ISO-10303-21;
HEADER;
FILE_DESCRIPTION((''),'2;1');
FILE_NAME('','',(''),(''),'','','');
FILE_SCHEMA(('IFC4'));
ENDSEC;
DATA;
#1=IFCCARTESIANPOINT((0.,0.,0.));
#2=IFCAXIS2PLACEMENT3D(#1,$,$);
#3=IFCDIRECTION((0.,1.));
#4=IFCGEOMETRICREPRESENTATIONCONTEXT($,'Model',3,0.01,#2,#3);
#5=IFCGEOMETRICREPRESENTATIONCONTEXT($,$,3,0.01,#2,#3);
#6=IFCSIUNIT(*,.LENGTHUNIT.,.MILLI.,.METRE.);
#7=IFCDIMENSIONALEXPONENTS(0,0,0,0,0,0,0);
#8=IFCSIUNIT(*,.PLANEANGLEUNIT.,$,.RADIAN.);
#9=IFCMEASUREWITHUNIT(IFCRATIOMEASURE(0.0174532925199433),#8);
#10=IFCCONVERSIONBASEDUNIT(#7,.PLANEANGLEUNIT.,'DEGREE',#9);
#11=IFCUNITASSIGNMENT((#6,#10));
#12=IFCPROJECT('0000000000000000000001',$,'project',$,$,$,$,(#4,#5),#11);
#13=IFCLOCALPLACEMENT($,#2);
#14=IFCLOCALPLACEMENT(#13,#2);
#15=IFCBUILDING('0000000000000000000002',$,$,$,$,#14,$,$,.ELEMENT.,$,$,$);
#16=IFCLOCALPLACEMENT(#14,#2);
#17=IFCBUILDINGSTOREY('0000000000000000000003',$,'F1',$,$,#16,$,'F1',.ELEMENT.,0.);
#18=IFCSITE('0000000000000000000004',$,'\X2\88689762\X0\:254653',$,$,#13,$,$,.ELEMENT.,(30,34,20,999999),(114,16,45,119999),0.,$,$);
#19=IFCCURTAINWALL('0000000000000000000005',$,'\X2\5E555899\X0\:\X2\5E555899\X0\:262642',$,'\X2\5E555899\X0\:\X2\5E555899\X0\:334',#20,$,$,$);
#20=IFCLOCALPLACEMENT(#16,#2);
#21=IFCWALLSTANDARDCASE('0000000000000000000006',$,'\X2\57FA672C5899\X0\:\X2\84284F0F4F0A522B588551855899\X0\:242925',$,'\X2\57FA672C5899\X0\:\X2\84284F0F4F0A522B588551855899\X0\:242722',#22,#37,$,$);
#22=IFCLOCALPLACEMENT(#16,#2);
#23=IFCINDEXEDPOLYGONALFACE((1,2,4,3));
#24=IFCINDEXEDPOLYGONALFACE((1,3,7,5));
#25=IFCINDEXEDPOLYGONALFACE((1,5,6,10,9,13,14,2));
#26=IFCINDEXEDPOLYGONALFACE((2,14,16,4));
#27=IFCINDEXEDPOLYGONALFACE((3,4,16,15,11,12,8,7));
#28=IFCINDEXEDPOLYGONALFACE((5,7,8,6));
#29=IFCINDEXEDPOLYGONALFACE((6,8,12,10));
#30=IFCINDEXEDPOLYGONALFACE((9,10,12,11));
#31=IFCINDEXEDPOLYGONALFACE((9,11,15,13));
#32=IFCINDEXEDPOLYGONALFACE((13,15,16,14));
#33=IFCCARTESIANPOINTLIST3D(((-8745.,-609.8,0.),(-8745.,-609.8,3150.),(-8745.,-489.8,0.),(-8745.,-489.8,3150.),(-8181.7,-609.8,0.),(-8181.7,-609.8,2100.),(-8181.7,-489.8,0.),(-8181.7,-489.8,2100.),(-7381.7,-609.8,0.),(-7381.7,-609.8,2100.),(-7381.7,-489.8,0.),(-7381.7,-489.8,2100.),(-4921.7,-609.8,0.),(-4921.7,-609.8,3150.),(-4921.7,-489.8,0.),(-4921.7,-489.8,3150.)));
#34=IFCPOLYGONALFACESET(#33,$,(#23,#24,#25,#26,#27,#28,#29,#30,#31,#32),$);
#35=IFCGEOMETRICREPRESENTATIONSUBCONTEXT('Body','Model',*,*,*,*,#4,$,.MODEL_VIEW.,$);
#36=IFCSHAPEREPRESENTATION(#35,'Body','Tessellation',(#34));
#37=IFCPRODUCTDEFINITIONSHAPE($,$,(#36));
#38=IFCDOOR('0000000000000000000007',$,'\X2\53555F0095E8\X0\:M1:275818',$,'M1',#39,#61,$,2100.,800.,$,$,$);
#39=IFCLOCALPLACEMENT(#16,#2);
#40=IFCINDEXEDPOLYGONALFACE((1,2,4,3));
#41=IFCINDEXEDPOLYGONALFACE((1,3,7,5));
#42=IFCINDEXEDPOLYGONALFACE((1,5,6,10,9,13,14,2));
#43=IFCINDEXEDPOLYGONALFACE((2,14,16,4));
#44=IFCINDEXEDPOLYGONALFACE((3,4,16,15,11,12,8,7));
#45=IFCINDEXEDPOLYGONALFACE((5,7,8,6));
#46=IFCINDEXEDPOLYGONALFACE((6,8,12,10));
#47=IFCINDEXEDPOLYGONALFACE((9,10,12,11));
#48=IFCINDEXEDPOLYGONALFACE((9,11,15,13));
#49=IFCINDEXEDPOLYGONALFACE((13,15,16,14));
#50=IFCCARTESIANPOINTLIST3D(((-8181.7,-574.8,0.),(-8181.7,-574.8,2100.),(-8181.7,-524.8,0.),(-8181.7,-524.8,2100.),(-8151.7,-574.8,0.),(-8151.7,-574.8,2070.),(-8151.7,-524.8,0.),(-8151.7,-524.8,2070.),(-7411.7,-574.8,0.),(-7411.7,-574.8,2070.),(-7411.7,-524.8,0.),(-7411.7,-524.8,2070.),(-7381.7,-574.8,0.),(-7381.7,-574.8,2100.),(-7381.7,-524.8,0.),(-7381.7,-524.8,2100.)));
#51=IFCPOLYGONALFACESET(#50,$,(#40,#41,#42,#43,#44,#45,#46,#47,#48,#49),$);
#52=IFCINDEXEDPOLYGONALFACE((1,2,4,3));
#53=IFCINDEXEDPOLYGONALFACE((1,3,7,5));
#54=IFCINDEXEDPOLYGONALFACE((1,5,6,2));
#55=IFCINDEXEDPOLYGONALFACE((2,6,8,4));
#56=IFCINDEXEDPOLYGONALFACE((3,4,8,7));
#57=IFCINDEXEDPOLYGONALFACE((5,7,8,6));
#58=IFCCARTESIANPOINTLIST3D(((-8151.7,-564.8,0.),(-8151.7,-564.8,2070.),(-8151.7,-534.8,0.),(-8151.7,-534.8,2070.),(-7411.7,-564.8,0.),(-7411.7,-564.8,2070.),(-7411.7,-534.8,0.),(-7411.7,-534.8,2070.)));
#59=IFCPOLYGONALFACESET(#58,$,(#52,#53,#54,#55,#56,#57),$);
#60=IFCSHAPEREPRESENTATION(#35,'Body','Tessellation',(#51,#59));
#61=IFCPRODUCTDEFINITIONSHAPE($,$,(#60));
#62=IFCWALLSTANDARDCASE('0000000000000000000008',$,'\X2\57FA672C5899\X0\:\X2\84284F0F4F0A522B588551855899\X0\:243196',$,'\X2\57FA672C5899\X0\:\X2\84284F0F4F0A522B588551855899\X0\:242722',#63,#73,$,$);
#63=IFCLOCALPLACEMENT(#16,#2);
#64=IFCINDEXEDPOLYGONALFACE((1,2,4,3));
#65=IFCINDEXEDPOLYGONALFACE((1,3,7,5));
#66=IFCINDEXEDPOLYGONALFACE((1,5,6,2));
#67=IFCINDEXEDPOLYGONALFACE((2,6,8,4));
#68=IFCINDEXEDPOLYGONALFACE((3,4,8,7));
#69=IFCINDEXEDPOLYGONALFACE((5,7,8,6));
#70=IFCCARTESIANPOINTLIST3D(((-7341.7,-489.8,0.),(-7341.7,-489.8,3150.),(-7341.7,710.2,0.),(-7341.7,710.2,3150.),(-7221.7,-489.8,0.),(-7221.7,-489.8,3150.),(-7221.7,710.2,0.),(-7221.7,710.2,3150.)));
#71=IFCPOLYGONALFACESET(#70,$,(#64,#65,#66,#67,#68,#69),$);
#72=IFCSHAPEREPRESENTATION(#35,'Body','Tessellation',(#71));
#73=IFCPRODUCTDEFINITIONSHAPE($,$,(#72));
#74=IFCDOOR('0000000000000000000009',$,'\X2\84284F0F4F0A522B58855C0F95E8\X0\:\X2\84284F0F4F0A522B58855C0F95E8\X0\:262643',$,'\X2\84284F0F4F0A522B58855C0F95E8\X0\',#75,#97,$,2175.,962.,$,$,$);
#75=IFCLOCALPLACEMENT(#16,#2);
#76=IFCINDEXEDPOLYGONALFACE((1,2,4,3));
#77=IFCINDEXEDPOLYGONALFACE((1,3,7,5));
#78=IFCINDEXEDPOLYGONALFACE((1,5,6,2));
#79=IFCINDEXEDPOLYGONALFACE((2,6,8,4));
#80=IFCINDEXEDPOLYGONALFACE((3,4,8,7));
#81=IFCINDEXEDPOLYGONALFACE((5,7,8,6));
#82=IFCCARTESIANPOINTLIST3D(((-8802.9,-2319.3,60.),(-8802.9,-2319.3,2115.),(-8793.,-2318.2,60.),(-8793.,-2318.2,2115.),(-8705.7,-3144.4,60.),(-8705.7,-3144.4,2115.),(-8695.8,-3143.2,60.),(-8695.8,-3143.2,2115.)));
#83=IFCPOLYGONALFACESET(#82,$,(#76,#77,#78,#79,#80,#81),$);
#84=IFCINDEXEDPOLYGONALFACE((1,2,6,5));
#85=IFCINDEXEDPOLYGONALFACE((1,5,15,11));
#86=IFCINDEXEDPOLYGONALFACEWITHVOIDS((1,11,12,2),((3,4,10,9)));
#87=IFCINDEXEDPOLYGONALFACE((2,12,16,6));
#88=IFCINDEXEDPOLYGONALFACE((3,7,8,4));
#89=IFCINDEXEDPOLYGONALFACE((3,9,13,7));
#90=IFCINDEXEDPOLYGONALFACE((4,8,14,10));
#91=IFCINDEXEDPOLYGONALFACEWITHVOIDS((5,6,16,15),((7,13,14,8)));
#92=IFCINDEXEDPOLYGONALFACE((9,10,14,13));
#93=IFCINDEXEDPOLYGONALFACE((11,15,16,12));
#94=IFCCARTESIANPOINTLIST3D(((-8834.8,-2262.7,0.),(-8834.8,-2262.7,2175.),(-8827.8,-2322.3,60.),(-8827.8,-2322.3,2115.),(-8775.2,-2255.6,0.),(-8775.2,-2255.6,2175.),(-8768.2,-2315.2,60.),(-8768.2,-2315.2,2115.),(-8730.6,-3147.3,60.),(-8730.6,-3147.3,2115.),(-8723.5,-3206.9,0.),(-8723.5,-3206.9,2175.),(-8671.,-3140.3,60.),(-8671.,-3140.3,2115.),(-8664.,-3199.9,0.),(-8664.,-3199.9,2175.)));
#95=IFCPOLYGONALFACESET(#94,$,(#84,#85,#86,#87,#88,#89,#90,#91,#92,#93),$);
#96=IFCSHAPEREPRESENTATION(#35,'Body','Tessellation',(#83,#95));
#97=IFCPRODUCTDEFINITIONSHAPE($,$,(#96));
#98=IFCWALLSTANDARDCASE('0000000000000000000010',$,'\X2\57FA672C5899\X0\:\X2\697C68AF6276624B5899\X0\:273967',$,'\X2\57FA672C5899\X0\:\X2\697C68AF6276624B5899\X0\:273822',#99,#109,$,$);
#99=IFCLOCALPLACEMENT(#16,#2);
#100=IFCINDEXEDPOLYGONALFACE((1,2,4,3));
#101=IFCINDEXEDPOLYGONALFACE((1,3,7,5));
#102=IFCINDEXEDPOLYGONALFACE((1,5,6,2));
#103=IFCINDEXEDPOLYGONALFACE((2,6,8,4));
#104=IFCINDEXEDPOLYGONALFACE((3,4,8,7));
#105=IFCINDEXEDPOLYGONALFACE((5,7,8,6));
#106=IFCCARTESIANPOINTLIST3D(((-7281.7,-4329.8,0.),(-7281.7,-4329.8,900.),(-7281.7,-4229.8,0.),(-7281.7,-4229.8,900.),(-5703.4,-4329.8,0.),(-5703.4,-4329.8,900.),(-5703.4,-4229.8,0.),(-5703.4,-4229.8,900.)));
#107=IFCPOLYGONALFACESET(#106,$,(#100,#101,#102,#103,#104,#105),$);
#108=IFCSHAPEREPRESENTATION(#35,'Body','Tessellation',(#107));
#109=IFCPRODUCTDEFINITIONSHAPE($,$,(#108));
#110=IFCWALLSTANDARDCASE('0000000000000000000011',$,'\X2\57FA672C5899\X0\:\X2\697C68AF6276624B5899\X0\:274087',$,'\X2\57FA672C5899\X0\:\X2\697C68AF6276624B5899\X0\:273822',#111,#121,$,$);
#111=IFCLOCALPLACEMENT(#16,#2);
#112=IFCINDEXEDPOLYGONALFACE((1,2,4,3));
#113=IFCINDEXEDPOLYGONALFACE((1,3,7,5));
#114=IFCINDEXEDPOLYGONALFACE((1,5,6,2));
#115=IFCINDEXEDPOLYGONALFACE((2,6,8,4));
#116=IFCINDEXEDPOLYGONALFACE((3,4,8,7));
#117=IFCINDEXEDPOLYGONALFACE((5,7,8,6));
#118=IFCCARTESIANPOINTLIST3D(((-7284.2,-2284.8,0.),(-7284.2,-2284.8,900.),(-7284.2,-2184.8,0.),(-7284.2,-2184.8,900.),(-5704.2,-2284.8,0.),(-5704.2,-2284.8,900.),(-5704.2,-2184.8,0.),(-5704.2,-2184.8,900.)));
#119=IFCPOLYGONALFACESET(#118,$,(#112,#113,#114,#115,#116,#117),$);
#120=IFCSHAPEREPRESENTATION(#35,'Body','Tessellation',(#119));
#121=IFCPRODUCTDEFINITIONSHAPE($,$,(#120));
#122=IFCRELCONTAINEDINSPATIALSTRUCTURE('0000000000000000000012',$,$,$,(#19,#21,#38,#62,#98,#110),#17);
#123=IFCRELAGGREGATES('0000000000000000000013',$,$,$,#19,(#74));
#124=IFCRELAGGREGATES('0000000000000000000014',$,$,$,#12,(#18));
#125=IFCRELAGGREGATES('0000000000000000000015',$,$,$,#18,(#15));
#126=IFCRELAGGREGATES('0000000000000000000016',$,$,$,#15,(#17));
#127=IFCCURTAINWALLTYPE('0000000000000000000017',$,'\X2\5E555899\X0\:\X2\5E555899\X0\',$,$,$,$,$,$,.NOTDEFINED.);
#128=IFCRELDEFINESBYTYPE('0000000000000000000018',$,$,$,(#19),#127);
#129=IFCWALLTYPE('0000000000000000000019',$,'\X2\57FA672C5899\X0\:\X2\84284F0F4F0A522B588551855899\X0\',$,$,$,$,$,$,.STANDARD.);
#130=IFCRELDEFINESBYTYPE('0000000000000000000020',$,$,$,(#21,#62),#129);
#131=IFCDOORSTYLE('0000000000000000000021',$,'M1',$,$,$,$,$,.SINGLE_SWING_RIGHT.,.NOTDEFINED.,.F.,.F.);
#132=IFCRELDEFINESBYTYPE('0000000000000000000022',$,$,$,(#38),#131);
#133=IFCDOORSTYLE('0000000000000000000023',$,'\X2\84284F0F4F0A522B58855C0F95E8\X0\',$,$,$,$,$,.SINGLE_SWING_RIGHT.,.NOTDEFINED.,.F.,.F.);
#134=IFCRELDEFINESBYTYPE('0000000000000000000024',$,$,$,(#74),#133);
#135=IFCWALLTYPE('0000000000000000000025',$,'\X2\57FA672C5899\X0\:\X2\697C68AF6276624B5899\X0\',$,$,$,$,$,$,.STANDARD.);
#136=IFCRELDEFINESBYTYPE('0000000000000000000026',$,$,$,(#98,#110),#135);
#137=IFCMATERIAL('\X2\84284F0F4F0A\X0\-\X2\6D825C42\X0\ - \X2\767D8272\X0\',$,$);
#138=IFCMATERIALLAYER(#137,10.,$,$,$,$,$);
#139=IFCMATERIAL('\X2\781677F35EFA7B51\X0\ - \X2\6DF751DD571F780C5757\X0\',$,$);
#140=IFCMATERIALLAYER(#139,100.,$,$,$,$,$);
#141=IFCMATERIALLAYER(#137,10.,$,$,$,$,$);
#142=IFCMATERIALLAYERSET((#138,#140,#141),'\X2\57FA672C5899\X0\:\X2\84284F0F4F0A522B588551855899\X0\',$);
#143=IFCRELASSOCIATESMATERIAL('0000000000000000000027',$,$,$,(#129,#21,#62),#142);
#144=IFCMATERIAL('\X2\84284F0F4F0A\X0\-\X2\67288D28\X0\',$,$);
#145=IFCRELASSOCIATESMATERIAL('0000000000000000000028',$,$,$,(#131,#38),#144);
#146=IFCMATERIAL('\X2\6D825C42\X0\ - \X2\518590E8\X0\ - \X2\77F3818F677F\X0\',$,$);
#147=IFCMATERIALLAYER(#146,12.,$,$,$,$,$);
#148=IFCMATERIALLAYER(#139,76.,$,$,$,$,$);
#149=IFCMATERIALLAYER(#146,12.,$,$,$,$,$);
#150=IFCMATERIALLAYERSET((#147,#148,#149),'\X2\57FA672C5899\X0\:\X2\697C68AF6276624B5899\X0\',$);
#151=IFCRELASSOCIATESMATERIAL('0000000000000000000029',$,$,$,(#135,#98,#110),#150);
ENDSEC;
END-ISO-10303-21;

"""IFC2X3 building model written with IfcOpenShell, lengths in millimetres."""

from ifc_helpers import new_model, entity, si_unit, converted_unit, direction, frame, frame_2d, origin, origin_2d_with_axis, place, context, subcontext, project, spatial, polyline, rectangle, outline, extrude, clip, bounded_halfspace, source, transform, mapped, material, layer, layer_set, layer_usage, type_object, type_shapes, element, fill, aggregate, save


model = new_model("IFC2X3")

# Units and contexts
model_context = context("Model", 3, precision=0.01, world=origin(), true_north=direction((0.0, 1.0)))
context_of_model = context(None, 3, precision=0.01, world=origin(), true_north=direction((0.0, 1.0)))
body_context = subcontext(model_context, "Body", "Model", "MODEL_VIEW")
ifc_project = project(units=[si_unit("LENGTHUNIT", "METRE", prefix="MILLI"), converted_unit("PLANEANGLEUNIT", "DEGREE", entity("IfcRatioMeasure", 0.0174532925199433), si_unit("PLANEANGLEUNIT", "RADIAN"), dimensions=[0, 0, 0, 0, 0, 0, 0])], contexts=[model_context, context_of_model])

# Site, building, storey
site_placement = place(None, origin())
site = spatial("IfcSite", under=ifc_project, at=site_placement, Name="表面:254653", CompositionType="ELEMENT", RefLatitude=(30, 34, 20, 999999), RefLongitude=(114, 16, 45, 119999), RefElevation=0.0)
building_placement = place(site_placement, origin())
building = spatial("IfcBuilding", under=site, at=building_placement, CompositionType="ELEMENT")
storey_placement = place(building_placement, origin())
storey = spatial("IfcBuildingStorey", under=building, at=storey_placement, Name="F1", LongName="F1", CompositionType="ELEMENT", Elevation=0.0)

# Curtain wall
curtain_wall_type_1 = type_object("IfcCurtainWallType", Name="幕墙:幕墙", PredefinedType="NOTDEFINED")
curtain_wall_1_placement = place(storey_placement, origin())
curtain_wall_1 = element("IfcCurtainWall", 1, at=curtain_wall_1_placement, inside=storey, type_object=curtain_wall_type_1, Name="幕墙:幕墙:262642", ObjectType="幕墙:幕墙:334")

# Wall, opening, door
ifc_material_1 = material(Name="萨伏伊-涂层 - 白色")
ifc_layer_1 = layer(ifc_material_1, 10.0)
ifc_material_2 = material(Name="砖石建筑 - 混凝土砌块")
ifc_layer_2 = layer(ifc_material_2, 100.0)
ifc_layer_3 = layer(ifc_material_1, 10.0)
ifc_layer_set_1 = layer_set([ifc_layer_1, ifc_layer_2, ifc_layer_3], Name="基本墙:萨伏伊别墅内墙")
ifc_layer_usage_1 = layer_usage(ifc_layer_set_1, "AXIS2", "NEGATIVE", 60.0)
wall_type_1 = type_object("IfcWallType", Name="基本墙:萨伏伊别墅内墙", PredefinedType="STANDARD", material=ifc_layer_set_1)
wall_1_placement = place(storey_placement, frame((-8745.0, -549.8, 0.0)))
wall_1 = element("IfcWallStandardCase", 2, at=wall_1_placement, inside=storey, type_object=wall_type_1, material=ifc_layer_usage_1, Name="基本墙:萨伏伊别墅内墙:242925", ObjectType="基本墙:萨伏伊别墅内墙:242722", context=body_context, shape_type="Clipping", body=[
    clip(extrude(rectangle(XDim=3823.3, YDim=120.0, at=frame_2d((1911.7, 0.0), x_axis=(-1.0, 0.0))), origin(), (0.0, 0.0, 1.0), 3150.0), bounded_halfspace(frame((0.0, -60.0, 3150.0), z_axis=(0.0, 0.0, -1.0), x_axis=(0.0, -1.0, 0.0)), True, frame((0.0, -60.0, 3150.0)), polyline([(0.0, 0.0), (3823.3, 0.0), (3823.3, 120.0), (3703.3, 120.0), (1523.3, 120.0), (1403.3, 120.0), (0.0, 120.0), (0.0, 0.0)]))),
])
opening_placement = place(wall_1_placement, frame((563.3, -60.0, 0.0)))
opening = element("IfcOpeningElement", 3, at=opening_placement, cuts=wall_1, ObjectType="Opening", context=body_context, shape_type="SweptSolid", body=[
    extrude(rectangle(XDim=2100.0, YDim=800.0, at=frame_2d((1050.0, 400.0), x_axis=(1.0, 0.0))), frame((0.0, 0.0, 0.0), z_axis=(0.0, 1.0, 0.0), x_axis=(0.0, 0.0, 1.0)), (0.0, 0.0, 1.0), 120.0),
])
ifc_material_3 = material(Name="萨伏伊-木质")
door_style_1 = type_object("IfcDoorStyle", Name="M1", ConstructionType="NOTDEFINED", OperationType="SINGLE_SWING_RIGHT", ParameterTakesPrecedence=False, Sizeable=False, material=ifc_material_3)
shared_shape_1 = source(origin(), body_context, "Body", "SweptSolid", [
    extrude(outline(polyline([(-1057.5, -400.0), (1042.5, -400.0), (1042.5, -370.0), (-1027.5, -370.0), (-1027.5, 370.0), (1042.5, 370.0), (1042.5, 400.0), (-1057.5, 400.0), (-1057.5, -400.0)])), frame((400.0, 85.0, 1042.5), z_axis=(0.0, -1.0, 0.0), x_axis=(0.0, 0.0, -1.0)), (0.0, 0.0, 1.0), 50.0),
    extrude(rectangle(XDim=740.0, YDim=30.0, at=origin_2d_with_axis()), frame((400.0, 60.0, 0.0)), (0.0, 0.0, 1.0), 2070.0),
])
type_shapes(door_style_1, [shared_shape_1])
door_1_placement = place(opening_placement, origin())
door_1 = element("IfcDoor", 4, at=door_1_placement, inside=storey, type_object=door_style_1, material=ifc_material_3, Name="单开门:M1:275818", ObjectType="M1", OverallHeight=2100.0, OverallWidth=800.0, context=body_context, shape_type="MappedRepresentation", body=[
    mapped(shared_shape_1, transform((0.0, 0.0, 0.0), scale=1.0)),
])
fill(opening, door_1)

# Wall
ifc_layer_usage_2 = layer_usage(ifc_layer_set_1, "AXIS2", "NEGATIVE", 60.0)
wall_2_placement = place(storey_placement, frame((-7281.7, -489.8, 0.0), z_axis=(0.0, 0.0, 1.0), x_axis=(0.0, 1.0, 0.0)))
element("IfcWallStandardCase", 5, at=wall_2_placement, inside=storey, type_object=wall_type_1, material=ifc_layer_usage_2, Name="基本墙:萨伏伊别墅内墙:243196", ObjectType="基本墙:萨伏伊别墅内墙:242722", context=body_context, shape_type="Clipping", body=[
    clip(extrude(rectangle(XDim=1200.0, YDim=120.0, at=frame_2d((600.0, 0.0), x_axis=(-1.0, 0.0))), origin(), (0.0, 0.0, 1.0), 3150.0), bounded_halfspace(frame((0.0, -60.0, 3150.0), z_axis=(0.0, 0.0, -1.0), x_axis=(-1.0, 0.0, 0.0)), True, frame((0.0, -60.0, 3150.0)), polyline([(0.0, 0.0), (1200.0, 0.0), (1200.0, 120.0), (1080.0, 120.0), (0.0, 120.0), (0.0, 0.0)]))),
])

# Door
door_style_2 = type_object("IfcDoorStyle", Name="萨伏伊别墅小门", ConstructionType="NOTDEFINED", OperationType="SINGLE_SWING_RIGHT", ParameterTakesPrecedence=False, Sizeable=False)
shared_shape_2 = source(origin(), body_context, "Body", "SweptSolid", [
    extrude(rectangle(XDim=830.8, YDim=10.0, at=origin_2d_with_axis()), frame((0.0, 0.0, 60.0), z_axis=(0.0, 0.0, 1.0), x_axis=(-1.0, 0.0, 0.0)), (0.0, 0.0, 1.0), 2055.0),
    extrude(outline(polyline([(-475.4, -1087.5), (475.4, -1087.5), (475.4, 1087.5), (-475.4, 1087.5), (-475.4, -1087.5)]), holes=[polyline([(415.4, -1027.5), (-415.4, -1027.5), (-415.4, 1027.5), (415.4, 1027.5), (415.4, -1027.5)])]), frame((0.0, -30.0, 1087.5), z_axis=(0.0, 1.0, 0.0), x_axis=(1.0, 0.0, 0.0)), (0.0, 0.0, 1.0), 60.0),
])
type_shapes(door_style_2, [shared_shape_2])
door_2_placement = place(curtain_wall_1_placement, frame((-8749.4, -2731.3, 0.0), z_axis=(0.0, 0.0, 1.0), x_axis=(-0.117005, 0.993131, 0.0)))
door_2 = element("IfcDoor", 6, at=door_2_placement, type_object=door_style_2, Name="萨伏伊别墅小门:萨伏伊别墅小门:262643", ObjectType="萨伏伊别墅小门", OverallHeight=2175.0, OverallWidth=962.0, context=body_context, shape_type="MappedRepresentation", body=[
    mapped(shared_shape_2, transform((0.0, 0.0, 0.0), scale=1.0)),
])
aggregate(curtain_wall_1, [door_2])

# Walls
ifc_material_4 = material(Name="涂层 - 内部 - 石膏板")
ifc_layer_4 = layer(ifc_material_4, 12.0)
ifc_layer_5 = layer(ifc_material_2, 76.0)
ifc_layer_6 = layer(ifc_material_4, 12.0)
ifc_layer_set_2 = layer_set([ifc_layer_4, ifc_layer_5, ifc_layer_6], Name="基本墙:楼梯扶手墙")
ifc_layer_usage_3 = layer_usage(ifc_layer_set_2, "AXIS2", "NEGATIVE", 50.0)
wall_type_2 = type_object("IfcWallType", Name="基本墙:楼梯扶手墙", PredefinedType="STANDARD", material=ifc_layer_set_2)
wall_3_placement = place(storey_placement, frame((-7281.7, -4279.8, 0.0)))
element("IfcWallStandardCase", 7, at=wall_3_placement, inside=storey, type_object=wall_type_2, material=ifc_layer_usage_3, Name="基本墙:楼梯扶手墙:273967", ObjectType="基本墙:楼梯扶手墙:273822", context=body_context, shape_type="SweptSolid", body=[
    extrude(rectangle(XDim=1578.3, YDim=100.0, at=frame_2d((789.2, 0.0), x_axis=(-1.0, 0.0))), origin(), (0.0, 0.0, 1.0), 900.0),
])
ifc_layer_usage_4 = layer_usage(ifc_layer_set_2, "AXIS2", "NEGATIVE", 50.0)
wall_4_placement = place(storey_placement, frame((-7284.2, -2234.8, 0.0)))
element("IfcWallStandardCase", 8, at=wall_4_placement, inside=storey, type_object=wall_type_2, material=ifc_layer_usage_4, Name="基本墙:楼梯扶手墙:274087", ObjectType="基本墙:楼梯扶手墙:273822", context=body_context, shape_type="SweptSolid", body=[
    extrude(rectangle(XDim=1580.0, YDim=100.0, at=frame_2d((790.0, 0.0), x_axis=(-1.0, 0.0))), origin(), (0.0, 0.0, 1.0), 900.0),
])

save(model, "model.ifc")
